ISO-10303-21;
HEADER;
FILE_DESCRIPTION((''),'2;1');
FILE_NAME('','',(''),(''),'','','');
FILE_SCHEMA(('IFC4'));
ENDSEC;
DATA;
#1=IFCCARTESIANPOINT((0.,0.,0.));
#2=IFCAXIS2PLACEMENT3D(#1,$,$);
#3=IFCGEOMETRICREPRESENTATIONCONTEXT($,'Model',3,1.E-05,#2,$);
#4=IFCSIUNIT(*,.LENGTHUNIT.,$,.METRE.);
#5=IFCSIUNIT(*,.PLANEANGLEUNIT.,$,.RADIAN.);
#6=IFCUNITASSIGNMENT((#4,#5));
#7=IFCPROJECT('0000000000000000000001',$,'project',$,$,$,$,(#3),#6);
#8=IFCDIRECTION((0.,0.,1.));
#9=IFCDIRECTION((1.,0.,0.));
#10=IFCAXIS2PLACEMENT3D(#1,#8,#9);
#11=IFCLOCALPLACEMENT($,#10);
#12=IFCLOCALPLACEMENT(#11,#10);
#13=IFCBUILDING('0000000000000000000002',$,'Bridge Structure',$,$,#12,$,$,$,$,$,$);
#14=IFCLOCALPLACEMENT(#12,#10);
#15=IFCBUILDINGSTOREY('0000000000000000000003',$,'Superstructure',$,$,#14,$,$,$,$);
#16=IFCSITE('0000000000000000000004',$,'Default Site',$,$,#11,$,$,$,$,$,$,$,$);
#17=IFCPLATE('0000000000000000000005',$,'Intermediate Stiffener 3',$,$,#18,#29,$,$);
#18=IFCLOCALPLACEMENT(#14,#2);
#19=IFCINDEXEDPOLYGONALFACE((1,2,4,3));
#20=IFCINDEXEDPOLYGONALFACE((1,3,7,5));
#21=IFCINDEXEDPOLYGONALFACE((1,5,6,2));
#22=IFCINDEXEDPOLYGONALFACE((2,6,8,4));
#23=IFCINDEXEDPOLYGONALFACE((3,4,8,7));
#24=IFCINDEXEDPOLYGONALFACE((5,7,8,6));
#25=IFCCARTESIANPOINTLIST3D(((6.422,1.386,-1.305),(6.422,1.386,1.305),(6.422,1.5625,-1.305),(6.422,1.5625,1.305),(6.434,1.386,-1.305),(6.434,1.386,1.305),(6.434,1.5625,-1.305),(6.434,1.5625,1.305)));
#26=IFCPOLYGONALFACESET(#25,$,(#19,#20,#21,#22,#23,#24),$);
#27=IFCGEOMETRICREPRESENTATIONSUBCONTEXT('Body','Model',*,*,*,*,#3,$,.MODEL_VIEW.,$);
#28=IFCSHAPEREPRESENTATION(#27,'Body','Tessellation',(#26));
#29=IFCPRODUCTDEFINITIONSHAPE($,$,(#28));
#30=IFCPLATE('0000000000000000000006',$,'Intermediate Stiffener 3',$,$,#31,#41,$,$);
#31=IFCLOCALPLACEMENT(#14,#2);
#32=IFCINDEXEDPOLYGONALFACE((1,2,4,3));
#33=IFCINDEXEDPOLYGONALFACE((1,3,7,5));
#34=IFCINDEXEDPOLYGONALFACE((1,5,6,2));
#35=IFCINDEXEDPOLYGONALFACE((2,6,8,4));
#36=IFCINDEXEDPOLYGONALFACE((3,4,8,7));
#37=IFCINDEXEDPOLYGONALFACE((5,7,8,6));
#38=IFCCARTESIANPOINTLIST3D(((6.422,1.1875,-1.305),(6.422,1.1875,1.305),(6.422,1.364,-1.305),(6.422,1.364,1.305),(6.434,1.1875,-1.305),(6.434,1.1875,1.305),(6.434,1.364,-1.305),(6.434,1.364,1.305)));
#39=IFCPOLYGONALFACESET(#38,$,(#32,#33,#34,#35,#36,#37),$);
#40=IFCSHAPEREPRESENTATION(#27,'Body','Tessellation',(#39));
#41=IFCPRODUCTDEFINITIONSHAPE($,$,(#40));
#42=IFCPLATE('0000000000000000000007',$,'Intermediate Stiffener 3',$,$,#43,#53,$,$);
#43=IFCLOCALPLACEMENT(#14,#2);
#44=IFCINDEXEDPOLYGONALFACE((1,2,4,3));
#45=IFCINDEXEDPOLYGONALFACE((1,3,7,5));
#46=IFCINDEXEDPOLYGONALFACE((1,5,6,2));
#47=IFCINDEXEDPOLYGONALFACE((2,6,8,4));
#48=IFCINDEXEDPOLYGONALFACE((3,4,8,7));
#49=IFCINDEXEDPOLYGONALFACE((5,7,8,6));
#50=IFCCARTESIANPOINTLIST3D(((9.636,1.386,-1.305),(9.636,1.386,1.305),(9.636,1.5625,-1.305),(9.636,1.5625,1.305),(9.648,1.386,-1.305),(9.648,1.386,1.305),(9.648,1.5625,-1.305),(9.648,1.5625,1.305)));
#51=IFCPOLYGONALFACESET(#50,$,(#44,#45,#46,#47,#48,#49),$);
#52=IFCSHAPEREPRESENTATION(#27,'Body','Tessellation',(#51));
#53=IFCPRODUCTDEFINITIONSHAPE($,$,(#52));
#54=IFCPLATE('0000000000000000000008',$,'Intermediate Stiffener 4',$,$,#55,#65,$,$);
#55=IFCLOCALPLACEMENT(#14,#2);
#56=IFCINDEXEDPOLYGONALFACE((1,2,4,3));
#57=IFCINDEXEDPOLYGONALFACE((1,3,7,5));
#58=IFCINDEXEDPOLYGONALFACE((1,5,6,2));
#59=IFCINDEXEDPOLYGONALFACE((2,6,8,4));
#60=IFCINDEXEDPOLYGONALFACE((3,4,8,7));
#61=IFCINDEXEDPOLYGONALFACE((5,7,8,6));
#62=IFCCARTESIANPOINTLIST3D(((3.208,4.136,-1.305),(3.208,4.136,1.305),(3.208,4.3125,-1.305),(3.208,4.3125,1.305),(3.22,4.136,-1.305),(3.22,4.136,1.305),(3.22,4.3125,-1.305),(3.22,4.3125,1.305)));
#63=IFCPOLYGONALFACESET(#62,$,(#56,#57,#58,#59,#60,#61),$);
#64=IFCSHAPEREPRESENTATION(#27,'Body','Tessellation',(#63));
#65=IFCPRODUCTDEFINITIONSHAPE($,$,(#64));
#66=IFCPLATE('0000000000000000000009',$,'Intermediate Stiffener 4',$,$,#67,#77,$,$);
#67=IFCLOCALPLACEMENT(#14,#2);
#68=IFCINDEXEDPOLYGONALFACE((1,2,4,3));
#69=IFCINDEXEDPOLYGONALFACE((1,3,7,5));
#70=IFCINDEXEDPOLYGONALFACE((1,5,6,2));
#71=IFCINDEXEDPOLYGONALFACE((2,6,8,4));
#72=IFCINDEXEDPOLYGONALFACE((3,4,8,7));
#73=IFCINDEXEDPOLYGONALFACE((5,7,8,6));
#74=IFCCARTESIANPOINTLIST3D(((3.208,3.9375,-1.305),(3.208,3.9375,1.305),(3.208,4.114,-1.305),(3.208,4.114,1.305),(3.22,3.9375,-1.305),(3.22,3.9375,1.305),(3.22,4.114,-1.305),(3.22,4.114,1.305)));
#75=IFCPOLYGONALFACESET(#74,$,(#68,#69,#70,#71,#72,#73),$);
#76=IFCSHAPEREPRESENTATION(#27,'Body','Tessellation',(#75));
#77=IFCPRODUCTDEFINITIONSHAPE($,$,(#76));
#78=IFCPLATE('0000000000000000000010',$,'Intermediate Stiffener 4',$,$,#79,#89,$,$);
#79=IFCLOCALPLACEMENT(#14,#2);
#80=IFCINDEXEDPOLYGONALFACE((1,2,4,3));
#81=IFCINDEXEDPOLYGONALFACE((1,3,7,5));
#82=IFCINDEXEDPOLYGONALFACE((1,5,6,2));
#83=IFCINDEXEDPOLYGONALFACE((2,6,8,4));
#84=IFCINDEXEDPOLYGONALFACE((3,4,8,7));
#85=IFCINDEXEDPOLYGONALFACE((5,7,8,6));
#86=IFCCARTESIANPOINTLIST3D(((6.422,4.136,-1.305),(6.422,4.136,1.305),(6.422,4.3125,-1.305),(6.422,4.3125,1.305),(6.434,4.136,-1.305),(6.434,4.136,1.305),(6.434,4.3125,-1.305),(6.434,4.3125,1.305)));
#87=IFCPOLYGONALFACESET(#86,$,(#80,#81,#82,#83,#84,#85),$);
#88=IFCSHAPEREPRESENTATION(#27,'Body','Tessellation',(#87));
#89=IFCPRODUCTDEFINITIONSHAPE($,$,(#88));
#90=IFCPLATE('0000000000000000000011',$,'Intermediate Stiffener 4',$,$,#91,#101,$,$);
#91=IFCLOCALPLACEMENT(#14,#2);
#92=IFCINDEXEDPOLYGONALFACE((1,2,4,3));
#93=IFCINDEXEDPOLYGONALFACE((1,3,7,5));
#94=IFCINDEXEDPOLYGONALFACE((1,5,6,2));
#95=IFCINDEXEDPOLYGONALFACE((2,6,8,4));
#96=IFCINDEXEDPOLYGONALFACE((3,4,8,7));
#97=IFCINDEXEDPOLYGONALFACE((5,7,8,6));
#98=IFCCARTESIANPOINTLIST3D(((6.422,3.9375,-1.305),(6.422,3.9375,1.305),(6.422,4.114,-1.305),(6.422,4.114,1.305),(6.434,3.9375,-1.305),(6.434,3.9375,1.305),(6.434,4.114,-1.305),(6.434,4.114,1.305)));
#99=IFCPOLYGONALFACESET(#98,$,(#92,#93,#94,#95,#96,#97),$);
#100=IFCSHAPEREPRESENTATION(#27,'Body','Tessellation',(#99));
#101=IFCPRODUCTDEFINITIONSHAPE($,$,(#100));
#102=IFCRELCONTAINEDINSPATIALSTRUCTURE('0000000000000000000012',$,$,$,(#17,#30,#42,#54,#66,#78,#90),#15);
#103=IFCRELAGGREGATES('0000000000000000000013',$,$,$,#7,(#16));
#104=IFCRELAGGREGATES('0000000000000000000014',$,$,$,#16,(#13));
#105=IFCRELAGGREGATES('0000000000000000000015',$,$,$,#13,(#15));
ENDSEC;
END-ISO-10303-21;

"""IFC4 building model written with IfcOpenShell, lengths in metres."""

from ifc_helpers import new_model, si_unit, frame, origin, origin_with_axes, origin_2d_with_axis, place, context, subcontext, project, spatial, rectangle, extrude, element, save


model = new_model("IFC4")

# Units and contexts
model_context = context("Model", 3, precision=1e-05, world=origin())
body_context = subcontext(model_context, "Body", "Model", "MODEL_VIEW")
ifc_project = project(units=[si_unit("LENGTHUNIT", "METRE"), si_unit("PLANEANGLEUNIT", "RADIAN")], contexts=[model_context])

# Site, building, storey
site_placement = place(None, origin_with_axes())
site = spatial("IfcSite", under=ifc_project, at=site_placement, Name="Default Site")
building_placement = place(site_placement, origin_with_axes())
building = spatial("IfcBuilding", under=site, at=building_placement, Name="Bridge Structure")
storey_placement = place(building_placement, origin_with_axes())
storey = spatial("IfcBuildingStorey", under=building, at=storey_placement, Name="Superstructure")

# Plates
for number, where, z_axis, x_axis, name in (
    (1, (6.428, 1.4743, -1.305), (0.0, 0.0, 1.0), (1.0, 0.0, 0.0), "Intermediate Stiffener 3"),
    (2, (6.428, 1.2757, -1.305), (0.0, 0.0, 1.0), (1.0, 0.0, 0.0), "Intermediate Stiffener 3"),
    (3, (9.642, 1.4743, -1.305), (0.0, 0.0, 1.0), (1.0, 0.0, 0.0), "Intermediate Stiffener 3"),
    (4, (3.214, 4.2243, -1.305), (0.0, 0.0, 1.0), (1.0, 0.0, 0.0), "Intermediate Stiffener 4"),
    (5, (3.214, 4.0258, -1.305), (0.0, 0.0, 1.0), (1.0, 0.0, 0.0), "Intermediate Stiffener 4"),
    (6, (6.428, 4.2243, -1.305), (0.0, 0.0, 1.0), (1.0, 0.0, 0.0), "Intermediate Stiffener 4"),
    (7, (6.428, 4.0258, -1.305), (0.0, 0.0, 1.0), (1.0, 0.0, 0.0), "Intermediate Stiffener 4"),
):
    element("IfcPlate", number, at=place(storey_placement, frame(where, z_axis=z_axis, x_axis=x_axis)), inside=storey, Name=name, context=body_context, shape_type="SweptSolid", body=[
        extrude(rectangle(XDim=0.012, YDim=0.1765, at=origin_2d_with_axis()), origin_with_axes(), (0.0, 0.0, 1.0), 2.61),
    ])

save(model, "model.ifc")
